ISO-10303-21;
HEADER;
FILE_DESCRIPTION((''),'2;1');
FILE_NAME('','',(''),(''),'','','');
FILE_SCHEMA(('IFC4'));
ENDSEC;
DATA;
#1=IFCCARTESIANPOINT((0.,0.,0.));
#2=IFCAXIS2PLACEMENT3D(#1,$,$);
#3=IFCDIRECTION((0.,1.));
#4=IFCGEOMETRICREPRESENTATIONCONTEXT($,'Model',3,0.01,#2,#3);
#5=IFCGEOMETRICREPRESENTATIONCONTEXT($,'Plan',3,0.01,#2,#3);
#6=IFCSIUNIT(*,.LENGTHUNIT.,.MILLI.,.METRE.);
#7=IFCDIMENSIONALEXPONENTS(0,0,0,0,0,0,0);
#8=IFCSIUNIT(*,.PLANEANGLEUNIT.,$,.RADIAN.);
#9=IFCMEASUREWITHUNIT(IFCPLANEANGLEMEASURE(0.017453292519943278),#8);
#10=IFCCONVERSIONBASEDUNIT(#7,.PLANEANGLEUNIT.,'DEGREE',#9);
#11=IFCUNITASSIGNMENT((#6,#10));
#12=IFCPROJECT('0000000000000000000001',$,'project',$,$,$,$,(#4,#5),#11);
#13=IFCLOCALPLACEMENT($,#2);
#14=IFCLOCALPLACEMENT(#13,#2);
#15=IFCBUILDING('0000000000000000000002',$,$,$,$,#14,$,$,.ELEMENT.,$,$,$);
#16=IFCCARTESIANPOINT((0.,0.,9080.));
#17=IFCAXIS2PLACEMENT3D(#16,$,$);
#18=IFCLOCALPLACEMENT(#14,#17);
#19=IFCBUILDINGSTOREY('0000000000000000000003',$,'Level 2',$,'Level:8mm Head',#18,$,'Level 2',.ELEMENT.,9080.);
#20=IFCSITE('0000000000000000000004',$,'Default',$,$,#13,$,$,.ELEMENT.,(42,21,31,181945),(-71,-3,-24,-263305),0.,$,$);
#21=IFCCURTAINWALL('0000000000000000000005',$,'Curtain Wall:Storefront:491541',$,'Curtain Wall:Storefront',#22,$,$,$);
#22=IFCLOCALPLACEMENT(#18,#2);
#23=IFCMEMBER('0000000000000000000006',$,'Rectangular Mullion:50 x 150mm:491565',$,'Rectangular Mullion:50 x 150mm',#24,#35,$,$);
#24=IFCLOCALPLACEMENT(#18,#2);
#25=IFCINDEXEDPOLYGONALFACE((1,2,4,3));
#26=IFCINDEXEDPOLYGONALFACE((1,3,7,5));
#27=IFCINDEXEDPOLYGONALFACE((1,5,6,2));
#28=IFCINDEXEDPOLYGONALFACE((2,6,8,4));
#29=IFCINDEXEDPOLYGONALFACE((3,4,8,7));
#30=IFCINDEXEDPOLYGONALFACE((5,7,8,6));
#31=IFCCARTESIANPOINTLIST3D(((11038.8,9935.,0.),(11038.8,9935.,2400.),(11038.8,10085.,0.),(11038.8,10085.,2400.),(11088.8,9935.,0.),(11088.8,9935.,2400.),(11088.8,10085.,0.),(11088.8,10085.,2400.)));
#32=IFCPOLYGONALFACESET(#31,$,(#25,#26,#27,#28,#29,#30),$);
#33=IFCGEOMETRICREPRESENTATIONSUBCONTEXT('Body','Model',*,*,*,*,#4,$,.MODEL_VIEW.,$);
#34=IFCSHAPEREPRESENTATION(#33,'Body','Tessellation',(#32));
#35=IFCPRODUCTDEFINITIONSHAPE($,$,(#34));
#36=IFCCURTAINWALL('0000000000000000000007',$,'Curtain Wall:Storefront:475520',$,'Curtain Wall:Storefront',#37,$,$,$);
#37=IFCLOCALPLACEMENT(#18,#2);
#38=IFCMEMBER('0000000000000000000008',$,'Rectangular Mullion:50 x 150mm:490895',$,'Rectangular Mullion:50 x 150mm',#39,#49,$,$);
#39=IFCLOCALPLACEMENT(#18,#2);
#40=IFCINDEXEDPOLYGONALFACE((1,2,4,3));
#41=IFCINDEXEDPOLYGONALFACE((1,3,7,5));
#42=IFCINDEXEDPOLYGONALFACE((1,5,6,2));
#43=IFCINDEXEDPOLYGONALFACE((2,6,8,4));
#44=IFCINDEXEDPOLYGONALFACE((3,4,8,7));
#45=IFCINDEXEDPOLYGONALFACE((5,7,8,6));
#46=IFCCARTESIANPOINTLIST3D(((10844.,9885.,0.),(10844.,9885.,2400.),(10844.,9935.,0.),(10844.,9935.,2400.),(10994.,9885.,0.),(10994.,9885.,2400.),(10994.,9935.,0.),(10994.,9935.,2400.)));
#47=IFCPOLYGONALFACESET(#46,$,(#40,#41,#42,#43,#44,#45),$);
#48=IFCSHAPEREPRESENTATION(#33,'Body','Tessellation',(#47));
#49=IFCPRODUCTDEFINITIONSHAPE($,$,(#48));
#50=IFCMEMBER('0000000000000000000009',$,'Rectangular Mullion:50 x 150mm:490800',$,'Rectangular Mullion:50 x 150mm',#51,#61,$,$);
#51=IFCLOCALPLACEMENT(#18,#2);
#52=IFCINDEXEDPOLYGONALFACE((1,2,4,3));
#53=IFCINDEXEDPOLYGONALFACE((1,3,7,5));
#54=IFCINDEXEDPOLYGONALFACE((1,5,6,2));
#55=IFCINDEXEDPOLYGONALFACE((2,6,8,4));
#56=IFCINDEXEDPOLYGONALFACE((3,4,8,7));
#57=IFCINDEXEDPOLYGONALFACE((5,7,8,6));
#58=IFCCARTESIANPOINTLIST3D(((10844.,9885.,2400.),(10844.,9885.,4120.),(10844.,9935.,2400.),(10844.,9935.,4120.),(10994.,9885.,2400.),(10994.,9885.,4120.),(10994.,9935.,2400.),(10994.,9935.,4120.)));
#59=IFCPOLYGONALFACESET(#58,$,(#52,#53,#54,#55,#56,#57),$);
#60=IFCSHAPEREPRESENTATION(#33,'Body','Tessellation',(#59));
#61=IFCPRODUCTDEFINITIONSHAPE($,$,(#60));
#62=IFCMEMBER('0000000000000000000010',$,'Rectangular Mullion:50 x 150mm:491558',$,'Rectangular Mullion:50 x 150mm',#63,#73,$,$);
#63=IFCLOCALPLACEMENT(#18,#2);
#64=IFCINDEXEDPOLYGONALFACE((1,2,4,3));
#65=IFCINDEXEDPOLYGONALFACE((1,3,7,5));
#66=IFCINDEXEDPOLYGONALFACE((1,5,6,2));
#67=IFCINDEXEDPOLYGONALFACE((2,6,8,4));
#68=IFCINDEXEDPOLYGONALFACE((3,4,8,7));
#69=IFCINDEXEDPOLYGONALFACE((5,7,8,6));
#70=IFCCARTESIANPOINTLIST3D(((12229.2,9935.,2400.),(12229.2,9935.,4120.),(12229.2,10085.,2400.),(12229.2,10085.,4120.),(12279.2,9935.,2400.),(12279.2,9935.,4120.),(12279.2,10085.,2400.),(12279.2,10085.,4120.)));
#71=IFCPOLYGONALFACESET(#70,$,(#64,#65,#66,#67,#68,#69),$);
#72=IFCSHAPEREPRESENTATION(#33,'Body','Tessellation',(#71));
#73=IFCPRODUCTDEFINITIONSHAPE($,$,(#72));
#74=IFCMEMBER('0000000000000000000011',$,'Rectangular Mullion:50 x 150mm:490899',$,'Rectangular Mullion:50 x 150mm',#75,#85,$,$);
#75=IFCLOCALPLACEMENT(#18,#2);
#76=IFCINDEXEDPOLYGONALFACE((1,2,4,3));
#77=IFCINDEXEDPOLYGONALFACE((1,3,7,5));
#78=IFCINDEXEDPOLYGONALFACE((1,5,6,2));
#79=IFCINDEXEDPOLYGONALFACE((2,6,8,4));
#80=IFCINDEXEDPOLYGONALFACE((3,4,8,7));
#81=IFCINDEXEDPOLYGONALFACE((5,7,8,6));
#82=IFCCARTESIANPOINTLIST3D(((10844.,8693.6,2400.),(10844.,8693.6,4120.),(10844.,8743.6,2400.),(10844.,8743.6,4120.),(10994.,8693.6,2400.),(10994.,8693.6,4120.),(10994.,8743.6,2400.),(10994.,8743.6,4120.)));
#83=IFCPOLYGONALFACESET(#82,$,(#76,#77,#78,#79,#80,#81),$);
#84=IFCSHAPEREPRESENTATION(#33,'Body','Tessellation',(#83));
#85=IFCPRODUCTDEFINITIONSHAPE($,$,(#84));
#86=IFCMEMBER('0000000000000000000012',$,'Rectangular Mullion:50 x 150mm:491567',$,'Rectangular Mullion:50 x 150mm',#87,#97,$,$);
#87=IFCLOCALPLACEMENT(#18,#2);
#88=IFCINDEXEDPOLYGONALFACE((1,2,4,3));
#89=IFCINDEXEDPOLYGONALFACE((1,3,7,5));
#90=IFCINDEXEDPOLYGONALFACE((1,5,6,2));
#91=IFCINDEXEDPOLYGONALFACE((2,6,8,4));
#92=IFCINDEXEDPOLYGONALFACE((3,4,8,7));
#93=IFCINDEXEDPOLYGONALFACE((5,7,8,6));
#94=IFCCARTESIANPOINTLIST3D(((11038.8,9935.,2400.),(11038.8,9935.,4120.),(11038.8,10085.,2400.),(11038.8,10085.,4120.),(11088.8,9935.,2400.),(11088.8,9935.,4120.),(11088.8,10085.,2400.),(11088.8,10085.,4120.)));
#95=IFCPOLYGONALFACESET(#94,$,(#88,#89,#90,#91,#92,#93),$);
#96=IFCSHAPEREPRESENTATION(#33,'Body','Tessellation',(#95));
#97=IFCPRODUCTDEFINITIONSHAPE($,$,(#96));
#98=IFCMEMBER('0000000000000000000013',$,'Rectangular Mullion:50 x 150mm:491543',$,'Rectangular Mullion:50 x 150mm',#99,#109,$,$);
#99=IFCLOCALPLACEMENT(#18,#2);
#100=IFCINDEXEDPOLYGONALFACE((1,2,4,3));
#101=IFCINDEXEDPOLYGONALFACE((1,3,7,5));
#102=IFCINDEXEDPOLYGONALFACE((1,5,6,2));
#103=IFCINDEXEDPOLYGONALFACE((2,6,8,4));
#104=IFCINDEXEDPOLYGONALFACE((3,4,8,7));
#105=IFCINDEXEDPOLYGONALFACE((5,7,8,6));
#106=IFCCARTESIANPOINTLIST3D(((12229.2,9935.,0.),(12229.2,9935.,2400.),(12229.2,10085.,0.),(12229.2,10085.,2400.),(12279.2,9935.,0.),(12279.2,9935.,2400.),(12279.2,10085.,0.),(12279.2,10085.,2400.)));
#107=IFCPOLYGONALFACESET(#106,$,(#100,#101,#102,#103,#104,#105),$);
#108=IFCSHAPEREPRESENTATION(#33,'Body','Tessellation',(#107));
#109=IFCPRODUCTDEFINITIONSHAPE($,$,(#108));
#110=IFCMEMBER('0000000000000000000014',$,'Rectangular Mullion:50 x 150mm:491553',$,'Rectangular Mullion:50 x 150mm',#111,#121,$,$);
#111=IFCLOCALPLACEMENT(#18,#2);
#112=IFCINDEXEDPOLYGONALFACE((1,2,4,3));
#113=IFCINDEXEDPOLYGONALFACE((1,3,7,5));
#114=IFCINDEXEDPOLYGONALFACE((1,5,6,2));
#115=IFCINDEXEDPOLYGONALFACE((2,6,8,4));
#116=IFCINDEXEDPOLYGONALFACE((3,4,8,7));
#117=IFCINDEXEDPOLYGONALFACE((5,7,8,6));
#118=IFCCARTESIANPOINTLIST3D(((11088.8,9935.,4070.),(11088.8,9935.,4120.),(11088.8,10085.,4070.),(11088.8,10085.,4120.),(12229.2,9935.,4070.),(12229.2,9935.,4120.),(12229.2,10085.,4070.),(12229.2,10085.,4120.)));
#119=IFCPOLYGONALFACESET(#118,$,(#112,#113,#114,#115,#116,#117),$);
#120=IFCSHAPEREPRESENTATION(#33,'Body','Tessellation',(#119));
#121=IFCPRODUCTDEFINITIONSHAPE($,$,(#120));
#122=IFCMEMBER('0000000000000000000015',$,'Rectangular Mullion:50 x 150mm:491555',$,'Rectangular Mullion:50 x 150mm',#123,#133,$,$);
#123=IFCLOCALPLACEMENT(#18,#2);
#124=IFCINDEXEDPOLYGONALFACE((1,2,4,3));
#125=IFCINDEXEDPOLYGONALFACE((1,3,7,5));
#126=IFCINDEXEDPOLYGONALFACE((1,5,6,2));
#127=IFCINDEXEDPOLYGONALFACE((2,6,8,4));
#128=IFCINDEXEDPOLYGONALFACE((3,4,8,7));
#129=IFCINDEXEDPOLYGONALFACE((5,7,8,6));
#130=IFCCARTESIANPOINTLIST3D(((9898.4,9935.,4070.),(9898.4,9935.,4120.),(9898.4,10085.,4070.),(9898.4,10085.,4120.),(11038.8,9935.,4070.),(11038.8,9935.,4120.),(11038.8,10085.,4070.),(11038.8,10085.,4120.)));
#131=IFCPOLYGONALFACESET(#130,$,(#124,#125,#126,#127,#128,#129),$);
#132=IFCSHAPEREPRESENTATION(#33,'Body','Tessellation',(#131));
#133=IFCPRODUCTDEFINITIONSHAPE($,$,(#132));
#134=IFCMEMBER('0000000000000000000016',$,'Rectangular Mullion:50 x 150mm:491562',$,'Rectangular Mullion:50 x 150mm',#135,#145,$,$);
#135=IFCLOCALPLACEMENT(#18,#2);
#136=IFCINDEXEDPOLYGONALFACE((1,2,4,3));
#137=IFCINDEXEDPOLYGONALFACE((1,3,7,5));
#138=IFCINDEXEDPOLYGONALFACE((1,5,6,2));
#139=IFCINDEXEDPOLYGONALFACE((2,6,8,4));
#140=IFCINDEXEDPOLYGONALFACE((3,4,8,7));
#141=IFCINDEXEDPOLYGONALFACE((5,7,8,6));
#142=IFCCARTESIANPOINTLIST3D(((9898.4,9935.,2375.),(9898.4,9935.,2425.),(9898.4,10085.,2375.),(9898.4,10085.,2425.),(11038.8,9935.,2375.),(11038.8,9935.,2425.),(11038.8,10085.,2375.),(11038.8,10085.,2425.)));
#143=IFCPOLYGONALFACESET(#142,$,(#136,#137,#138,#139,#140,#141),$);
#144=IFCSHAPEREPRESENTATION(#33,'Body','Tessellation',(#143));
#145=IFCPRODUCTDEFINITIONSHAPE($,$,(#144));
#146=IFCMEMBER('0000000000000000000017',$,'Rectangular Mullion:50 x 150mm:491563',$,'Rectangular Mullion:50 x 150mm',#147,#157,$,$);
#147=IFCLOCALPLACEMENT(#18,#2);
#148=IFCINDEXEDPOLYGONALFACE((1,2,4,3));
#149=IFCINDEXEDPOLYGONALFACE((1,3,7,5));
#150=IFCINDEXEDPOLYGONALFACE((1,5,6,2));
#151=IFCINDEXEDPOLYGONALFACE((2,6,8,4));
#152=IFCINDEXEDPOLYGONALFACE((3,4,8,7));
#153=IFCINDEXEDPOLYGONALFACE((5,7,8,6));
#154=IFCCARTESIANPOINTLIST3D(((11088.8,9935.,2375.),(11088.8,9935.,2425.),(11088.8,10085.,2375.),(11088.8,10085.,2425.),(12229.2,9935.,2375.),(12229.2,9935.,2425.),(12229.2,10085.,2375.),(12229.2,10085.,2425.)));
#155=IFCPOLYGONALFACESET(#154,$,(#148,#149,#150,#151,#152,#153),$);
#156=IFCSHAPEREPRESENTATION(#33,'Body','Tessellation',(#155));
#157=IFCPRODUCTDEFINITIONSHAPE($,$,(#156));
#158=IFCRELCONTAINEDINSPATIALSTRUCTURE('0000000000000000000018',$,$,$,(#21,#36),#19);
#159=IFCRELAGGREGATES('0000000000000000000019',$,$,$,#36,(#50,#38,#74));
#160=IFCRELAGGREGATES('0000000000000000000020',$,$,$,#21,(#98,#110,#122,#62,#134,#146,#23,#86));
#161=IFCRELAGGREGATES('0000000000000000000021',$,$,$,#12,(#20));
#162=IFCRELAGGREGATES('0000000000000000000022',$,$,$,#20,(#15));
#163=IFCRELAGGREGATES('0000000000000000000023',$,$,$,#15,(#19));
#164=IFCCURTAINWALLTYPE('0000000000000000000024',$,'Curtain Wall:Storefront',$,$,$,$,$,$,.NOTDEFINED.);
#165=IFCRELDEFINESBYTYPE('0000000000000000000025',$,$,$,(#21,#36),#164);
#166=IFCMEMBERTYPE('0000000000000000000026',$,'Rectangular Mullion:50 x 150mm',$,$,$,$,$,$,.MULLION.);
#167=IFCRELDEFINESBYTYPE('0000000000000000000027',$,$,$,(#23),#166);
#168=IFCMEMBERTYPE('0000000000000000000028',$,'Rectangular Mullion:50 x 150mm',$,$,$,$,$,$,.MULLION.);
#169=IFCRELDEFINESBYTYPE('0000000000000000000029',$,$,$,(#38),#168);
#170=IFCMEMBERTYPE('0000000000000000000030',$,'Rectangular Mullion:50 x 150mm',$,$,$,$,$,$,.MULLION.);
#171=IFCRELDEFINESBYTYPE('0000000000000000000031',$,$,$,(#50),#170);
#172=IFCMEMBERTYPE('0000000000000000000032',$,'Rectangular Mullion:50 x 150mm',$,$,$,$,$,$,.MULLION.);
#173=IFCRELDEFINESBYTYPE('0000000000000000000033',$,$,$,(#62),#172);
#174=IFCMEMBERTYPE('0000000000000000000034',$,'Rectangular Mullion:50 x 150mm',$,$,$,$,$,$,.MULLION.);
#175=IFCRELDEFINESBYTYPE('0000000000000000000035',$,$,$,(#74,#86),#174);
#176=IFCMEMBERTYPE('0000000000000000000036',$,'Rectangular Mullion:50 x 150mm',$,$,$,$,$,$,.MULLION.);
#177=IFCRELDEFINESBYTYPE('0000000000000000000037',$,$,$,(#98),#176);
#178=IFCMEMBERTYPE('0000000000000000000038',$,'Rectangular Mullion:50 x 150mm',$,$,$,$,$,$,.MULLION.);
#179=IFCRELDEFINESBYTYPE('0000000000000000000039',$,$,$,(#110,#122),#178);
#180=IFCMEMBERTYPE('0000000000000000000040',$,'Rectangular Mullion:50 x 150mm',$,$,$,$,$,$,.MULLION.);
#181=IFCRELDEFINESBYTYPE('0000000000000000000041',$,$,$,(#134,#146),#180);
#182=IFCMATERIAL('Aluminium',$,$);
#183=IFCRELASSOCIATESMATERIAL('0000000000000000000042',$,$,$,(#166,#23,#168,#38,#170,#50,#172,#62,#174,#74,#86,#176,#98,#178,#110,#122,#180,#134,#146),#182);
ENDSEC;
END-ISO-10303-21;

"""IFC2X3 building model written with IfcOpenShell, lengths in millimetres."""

from ifc_helpers import new_model, entity, si_unit, converted_unit, direction, frame, origin, origin_2d_with_axis, place, context, subcontext, project, spatial, rectangle, extrude, source, transform, mapped, material, type_object, type_shapes, element, aggregate, save


model = new_model("IFC2X3")

# Units and contexts
model_context = context("Model", 3, precision=0.01, world=origin(), true_north=direction((0.0, 1.0)))
plan_context = context("Plan", 3, precision=0.01, world=origin(), true_north=direction((0.0, 1.0)))
body_context = subcontext(model_context, "Body", "Model", "MODEL_VIEW")
ifc_project = project(units=[si_unit("LENGTHUNIT", "METRE", prefix="MILLI"), converted_unit("PLANEANGLEUNIT", "DEGREE", entity("IfcPlaneAngleMeasure", 0.017453292519943278), si_unit("PLANEANGLEUNIT", "RADIAN"), dimensions=[0, 0, 0, 0, 0, 0, 0])], contexts=[model_context, plan_context])

# Site, building, storey
site_placement = place(None, origin())
site = spatial("IfcSite", under=ifc_project, at=site_placement, Name="Default", CompositionType="ELEMENT", RefLatitude=(42, 21, 31, 181945), RefLongitude=(-71, -3, -24, -263305), RefElevation=0.0)
building_placement = place(site_placement, origin())
building = spatial("IfcBuilding", under=site, at=building_placement, CompositionType="ELEMENT")
storey_placement = place(building_placement, frame((0.0, 0.0, 9080.0)))
storey = spatial("IfcBuildingStorey", under=building, at=storey_placement, Name="Level 2", ObjectType="Level:8mm Head", LongName="Level 2", CompositionType="ELEMENT", Elevation=9080.0)

# Curtain wall, member
curtain_wall_type = type_object("IfcCurtainWallType", Name="Curtain Wall:Storefront", PredefinedType="NOTDEFINED")
curtain_wall_1_placement = place(storey_placement, frame((0.0, 0.0, -9080.0)))
curtain_wall_1 = element("IfcCurtainWall", 1, at=curtain_wall_1_placement, inside=storey, type_object=curtain_wall_type, Name="Curtain Wall:Storefront:491541", ObjectType="Curtain Wall:Storefront")
ifc_material_1 = material(Name="Aluminium")
member_type_1 = type_object("IfcMemberType", Name="Rectangular Mullion:50 x 150mm", PredefinedType="MULLION", material=ifc_material_1)
shared_shape_1 = source(origin(), body_context, "Body", "SweptSolid", [
    extrude(rectangle(XDim=50.0, YDim=150.0, at=origin_2d_with_axis()), frame((0.0, 0.0, -2400.0), z_axis=(0.0, 0.0, 1.0), x_axis=(-1.0, 0.0, 0.0)), (0.0, 0.0, 1.0), 2400.0),
])
type_shapes(member_type_1, [shared_shape_1])
member_1_placement = place(curtain_wall_1_placement, frame((11063.8, 10010.0, 9080.0), z_axis=(0.0, 0.0, -1.0), x_axis=(1.0, 0.0, 0.0)))
member_1 = element("IfcMember", 2, at=member_1_placement, type_object=member_type_1, material=ifc_material_1, Name="Rectangular Mullion:50 x 150mm:491565", ObjectType="Rectangular Mullion:50 x 150mm", context=body_context, shape_type="MappedRepresentation", body=[
    mapped(shared_shape_1, transform((0.0, 0.0, 0.0), scale=1.0)),
])

# Curtain wall, members
curtain_wall_2_placement = place(storey_placement, frame((0.0, 0.0, -9080.0)))
curtain_wall_2 = element("IfcCurtainWall", 3, at=curtain_wall_2_placement, inside=storey, type_object=curtain_wall_type, Name="Curtain Wall:Storefront:475520", ObjectType="Curtain Wall:Storefront")
member_type_2 = type_object("IfcMemberType", Name="Rectangular Mullion:50 x 150mm", PredefinedType="MULLION", material=ifc_material_1)
shared_shape_2 = source(origin(), body_context, "Body", "SweptSolid", [
    extrude(rectangle(XDim=50.0, YDim=150.0, at=origin_2d_with_axis()), frame((-25.0, 0.0, -2400.0), z_axis=(0.0, 0.0, 1.0), x_axis=(-1.0, 0.0, 0.0)), (0.0, 0.0, 1.0), 2400.0),
])
type_shapes(member_type_2, [shared_shape_2])
member_2_placement = place(curtain_wall_2_placement, frame((10919.0, 9935.0, 11480.0), z_axis=(0.0, 0.0, 1.0), x_axis=(0.0, 1.0, 0.0)))
member_2 = element("IfcMember", 4, at=member_2_placement, type_object=member_type_2, material=ifc_material_1, Name="Rectangular Mullion:50 x 150mm:490895", ObjectType="Rectangular Mullion:50 x 150mm", context=body_context, shape_type="MappedRepresentation", body=[
    mapped(shared_shape_2, transform((0.0, 0.0, 0.0), scale=1.0)),
])
member_type_3 = type_object("IfcMemberType", Name="Rectangular Mullion:50 x 150mm", PredefinedType="MULLION", material=ifc_material_1)
shared_shape_3 = source(origin(), body_context, "Body", "SweptSolid", [
    extrude(rectangle(XDim=50.0, YDim=150.0, at=origin_2d_with_axis()), frame((-25.0, 0.0, -1720.0), z_axis=(0.0, 0.0, 1.0), x_axis=(-1.0, 0.0, 0.0)), (0.0, 0.0, 1.0), 1720.0),
])
type_shapes(member_type_3, [shared_shape_3])
member_3_placement = place(curtain_wall_2_placement, frame((10919.0, 9935.0, 13200.0), z_axis=(0.0, 0.0, 1.0), x_axis=(0.0, 1.0, 0.0)))
member_3 = element("IfcMember", 5, at=member_3_placement, type_object=member_type_3, material=ifc_material_1, Name="Rectangular Mullion:50 x 150mm:490800", ObjectType="Rectangular Mullion:50 x 150mm", context=body_context, shape_type="MappedRepresentation", body=[
    mapped(shared_shape_3, transform((0.0, 0.0, 0.0), scale=1.0)),
])

# Members
member_type_4 = type_object("IfcMemberType", Name="Rectangular Mullion:50 x 150mm", PredefinedType="MULLION", material=ifc_material_1)
shared_shape_4 = source(origin(), body_context, "Body", "SweptSolid", [
    extrude(rectangle(XDim=50.0, YDim=150.0, at=origin_2d_with_axis()), frame((-25.0, 0.0, -1720.0), z_axis=(0.0, 0.0, 1.0), x_axis=(-1.0, 0.0, 0.0)), (0.0, 0.0, 1.0), 1720.0),
])
type_shapes(member_type_4, [shared_shape_4])
member_4_placement = place(curtain_wall_1_placement, frame((12279.2, 10010.0, 11480.0), z_axis=(0.0, 0.0, -1.0), x_axis=(1.0, 0.0, 0.0)))
member_4 = element("IfcMember", 6, at=member_4_placement, type_object=member_type_4, material=ifc_material_1, Name="Rectangular Mullion:50 x 150mm:491558", ObjectType="Rectangular Mullion:50 x 150mm", context=body_context, shape_type="MappedRepresentation", body=[
    mapped(shared_shape_4, transform((0.0, 0.0, 0.0), scale=1.0)),
])
member_type_5 = type_object("IfcMemberType", Name="Rectangular Mullion:50 x 150mm", PredefinedType="MULLION", material=ifc_material_1)
shared_shape_5 = source(origin(), body_context, "Body", "SweptSolid", [
    extrude(rectangle(XDim=50.0, YDim=150.0, at=origin_2d_with_axis()), frame((0.0, 0.0, -1720.0), z_axis=(0.0, 0.0, 1.0), x_axis=(-1.0, 0.0, 0.0)), (0.0, 0.0, 1.0), 1720.0),
])
type_shapes(member_type_5, [shared_shape_5])
member_5_placement = place(curtain_wall_2_placement, frame((10919.0, 8718.6, 11480.0), z_axis=(0.0, 0.0, -1.0), x_axis=(0.0, -1.0, 0.0)))
member_5 = element("IfcMember", 7, at=member_5_placement, type_object=member_type_5, material=ifc_material_1, Name="Rectangular Mullion:50 x 150mm:490899", ObjectType="Rectangular Mullion:50 x 150mm", context=body_context, shape_type="MappedRepresentation", body=[
    mapped(shared_shape_5, transform((0.0, 0.0, 0.0), scale=1.0)),
])
aggregate(curtain_wall_2, [member_3, member_2, member_5])
member_6_placement = place(curtain_wall_1_placement, frame((11063.8, 10010.0, 11480.0), z_axis=(0.0, 0.0, -1.0), x_axis=(1.0, 0.0, 0.0)))
member_6 = element("IfcMember", 8, at=member_6_placement, type_object=member_type_5, material=ifc_material_1, Name="Rectangular Mullion:50 x 150mm:491567", ObjectType="Rectangular Mullion:50 x 150mm", context=body_context, shape_type="MappedRepresentation", body=[
    mapped(shared_shape_5, transform((0.0, 0.0, 0.0), scale=1.0)),
])
member_type_6 = type_object("IfcMemberType", Name="Rectangular Mullion:50 x 150mm", PredefinedType="MULLION", material=ifc_material_1)
shared_shape_6 = source(origin(), body_context, "Body", "SweptSolid", [
    extrude(rectangle(XDim=50.0, YDim=150.0, at=origin_2d_with_axis()), frame((-25.0, 0.0, -2400.0), z_axis=(0.0, 0.0, 1.0), x_axis=(-1.0, 0.0, 0.0)), (0.0, 0.0, 1.0), 2400.0),
])
type_shapes(member_type_6, [shared_shape_6])
member_7_placement = place(curtain_wall_1_placement, frame((12279.2, 10010.0, 9080.0), z_axis=(0.0, 0.0, -1.0), x_axis=(1.0, 0.0, 0.0)))
member_7 = element("IfcMember", 9, at=member_7_placement, type_object=member_type_6, material=ifc_material_1, Name="Rectangular Mullion:50 x 150mm:491543", ObjectType="Rectangular Mullion:50 x 150mm", context=body_context, shape_type="MappedRepresentation", body=[
    mapped(shared_shape_6, transform((0.0, 0.0, 0.0), scale=1.0)),
])
member_type_7 = type_object("IfcMemberType", Name="Rectangular Mullion:50 x 150mm", PredefinedType="MULLION", material=ifc_material_1)
shared_shape_7 = source(origin(), body_context, "Body", "SweptSolid", [
    extrude(rectangle(XDim=50.0, YDim=150.0, at=origin_2d_with_axis()), frame((-25.0, 0.0, -1140.4), z_axis=(0.0, 0.0, 1.0), x_axis=(-1.0, 0.0, 0.0)), (0.0, 0.0, 1.0), 1140.4),
])
type_shapes(member_type_7, [shared_shape_7])
member_8_placement = place(curtain_wall_1_placement, frame((12229.2, 10010.0, 13200.0), z_axis=(1.0, 0.0, 0.0), x_axis=(0.0, 0.0, 1.0)))
member_8 = element("IfcMember", 10, at=member_8_placement, type_object=member_type_7, material=ifc_material_1, Name="Rectangular Mullion:50 x 150mm:491553", ObjectType="Rectangular Mullion:50 x 150mm", context=body_context, shape_type="MappedRepresentation", body=[
    mapped(shared_shape_7, transform((0.0, 0.0, 0.0), scale=1.0)),
])
member_9_placement = place(curtain_wall_1_placement, frame((11038.8, 10010.0, 13200.0), z_axis=(1.0, 0.0, 0.0), x_axis=(0.0, 0.0, 1.0)))
member_9 = element("IfcMember", 11, at=member_9_placement, type_object=member_type_7, material=ifc_material_1, Name="Rectangular Mullion:50 x 150mm:491555", ObjectType="Rectangular Mullion:50 x 150mm", context=body_context, shape_type="MappedRepresentation", body=[
    mapped(shared_shape_7, transform((0.0, 0.0, 0.0), scale=1.0)),
])
member_type_8 = type_object("IfcMemberType", Name="Rectangular Mullion:50 x 150mm", PredefinedType="MULLION", material=ifc_material_1)
shared_shape_8 = source(origin(), body_context, "Body", "SweptSolid", [
    extrude(rectangle(XDim=50.0, YDim=150.0, at=origin_2d_with_axis()), frame((0.0, 0.0, -1140.4), z_axis=(0.0, 0.0, 1.0), x_axis=(-1.0, 0.0, 0.0)), (0.0, 0.0, 1.0), 1140.4),
])
type_shapes(member_type_8, [shared_shape_8])
member_10_placement = place(curtain_wall_1_placement, frame((11038.8, 10010.0, 11480.0), z_axis=(1.0, 0.0, 0.0), x_axis=(0.0, 0.0, 1.0)))
member_10 = element("IfcMember", 12, at=member_10_placement, type_object=member_type_8, material=ifc_material_1, Name="Rectangular Mullion:50 x 150mm:491562", ObjectType="Rectangular Mullion:50 x 150mm", context=body_context, shape_type="MappedRepresentation", body=[
    mapped(shared_shape_8, transform((0.0, 0.0, 0.0), scale=1.0)),
])
member_11_placement = place(curtain_wall_1_placement, frame((12229.2, 10010.0, 11480.0), z_axis=(1.0, 0.0, 0.0), x_axis=(0.0, 0.0, 1.0)))
member_11 = element("IfcMember", 13, at=member_11_placement, type_object=member_type_8, material=ifc_material_1, Name="Rectangular Mullion:50 x 150mm:491563", ObjectType="Rectangular Mullion:50 x 150mm", context=body_context, shape_type="MappedRepresentation", body=[
    mapped(shared_shape_8, transform((0.0, 0.0, 0.0), scale=1.0)),
])

aggregate(curtain_wall_1, [member_7, member_8, member_9, member_4, member_10, member_11, member_1, member_6])

save(model, "model.ifc")
